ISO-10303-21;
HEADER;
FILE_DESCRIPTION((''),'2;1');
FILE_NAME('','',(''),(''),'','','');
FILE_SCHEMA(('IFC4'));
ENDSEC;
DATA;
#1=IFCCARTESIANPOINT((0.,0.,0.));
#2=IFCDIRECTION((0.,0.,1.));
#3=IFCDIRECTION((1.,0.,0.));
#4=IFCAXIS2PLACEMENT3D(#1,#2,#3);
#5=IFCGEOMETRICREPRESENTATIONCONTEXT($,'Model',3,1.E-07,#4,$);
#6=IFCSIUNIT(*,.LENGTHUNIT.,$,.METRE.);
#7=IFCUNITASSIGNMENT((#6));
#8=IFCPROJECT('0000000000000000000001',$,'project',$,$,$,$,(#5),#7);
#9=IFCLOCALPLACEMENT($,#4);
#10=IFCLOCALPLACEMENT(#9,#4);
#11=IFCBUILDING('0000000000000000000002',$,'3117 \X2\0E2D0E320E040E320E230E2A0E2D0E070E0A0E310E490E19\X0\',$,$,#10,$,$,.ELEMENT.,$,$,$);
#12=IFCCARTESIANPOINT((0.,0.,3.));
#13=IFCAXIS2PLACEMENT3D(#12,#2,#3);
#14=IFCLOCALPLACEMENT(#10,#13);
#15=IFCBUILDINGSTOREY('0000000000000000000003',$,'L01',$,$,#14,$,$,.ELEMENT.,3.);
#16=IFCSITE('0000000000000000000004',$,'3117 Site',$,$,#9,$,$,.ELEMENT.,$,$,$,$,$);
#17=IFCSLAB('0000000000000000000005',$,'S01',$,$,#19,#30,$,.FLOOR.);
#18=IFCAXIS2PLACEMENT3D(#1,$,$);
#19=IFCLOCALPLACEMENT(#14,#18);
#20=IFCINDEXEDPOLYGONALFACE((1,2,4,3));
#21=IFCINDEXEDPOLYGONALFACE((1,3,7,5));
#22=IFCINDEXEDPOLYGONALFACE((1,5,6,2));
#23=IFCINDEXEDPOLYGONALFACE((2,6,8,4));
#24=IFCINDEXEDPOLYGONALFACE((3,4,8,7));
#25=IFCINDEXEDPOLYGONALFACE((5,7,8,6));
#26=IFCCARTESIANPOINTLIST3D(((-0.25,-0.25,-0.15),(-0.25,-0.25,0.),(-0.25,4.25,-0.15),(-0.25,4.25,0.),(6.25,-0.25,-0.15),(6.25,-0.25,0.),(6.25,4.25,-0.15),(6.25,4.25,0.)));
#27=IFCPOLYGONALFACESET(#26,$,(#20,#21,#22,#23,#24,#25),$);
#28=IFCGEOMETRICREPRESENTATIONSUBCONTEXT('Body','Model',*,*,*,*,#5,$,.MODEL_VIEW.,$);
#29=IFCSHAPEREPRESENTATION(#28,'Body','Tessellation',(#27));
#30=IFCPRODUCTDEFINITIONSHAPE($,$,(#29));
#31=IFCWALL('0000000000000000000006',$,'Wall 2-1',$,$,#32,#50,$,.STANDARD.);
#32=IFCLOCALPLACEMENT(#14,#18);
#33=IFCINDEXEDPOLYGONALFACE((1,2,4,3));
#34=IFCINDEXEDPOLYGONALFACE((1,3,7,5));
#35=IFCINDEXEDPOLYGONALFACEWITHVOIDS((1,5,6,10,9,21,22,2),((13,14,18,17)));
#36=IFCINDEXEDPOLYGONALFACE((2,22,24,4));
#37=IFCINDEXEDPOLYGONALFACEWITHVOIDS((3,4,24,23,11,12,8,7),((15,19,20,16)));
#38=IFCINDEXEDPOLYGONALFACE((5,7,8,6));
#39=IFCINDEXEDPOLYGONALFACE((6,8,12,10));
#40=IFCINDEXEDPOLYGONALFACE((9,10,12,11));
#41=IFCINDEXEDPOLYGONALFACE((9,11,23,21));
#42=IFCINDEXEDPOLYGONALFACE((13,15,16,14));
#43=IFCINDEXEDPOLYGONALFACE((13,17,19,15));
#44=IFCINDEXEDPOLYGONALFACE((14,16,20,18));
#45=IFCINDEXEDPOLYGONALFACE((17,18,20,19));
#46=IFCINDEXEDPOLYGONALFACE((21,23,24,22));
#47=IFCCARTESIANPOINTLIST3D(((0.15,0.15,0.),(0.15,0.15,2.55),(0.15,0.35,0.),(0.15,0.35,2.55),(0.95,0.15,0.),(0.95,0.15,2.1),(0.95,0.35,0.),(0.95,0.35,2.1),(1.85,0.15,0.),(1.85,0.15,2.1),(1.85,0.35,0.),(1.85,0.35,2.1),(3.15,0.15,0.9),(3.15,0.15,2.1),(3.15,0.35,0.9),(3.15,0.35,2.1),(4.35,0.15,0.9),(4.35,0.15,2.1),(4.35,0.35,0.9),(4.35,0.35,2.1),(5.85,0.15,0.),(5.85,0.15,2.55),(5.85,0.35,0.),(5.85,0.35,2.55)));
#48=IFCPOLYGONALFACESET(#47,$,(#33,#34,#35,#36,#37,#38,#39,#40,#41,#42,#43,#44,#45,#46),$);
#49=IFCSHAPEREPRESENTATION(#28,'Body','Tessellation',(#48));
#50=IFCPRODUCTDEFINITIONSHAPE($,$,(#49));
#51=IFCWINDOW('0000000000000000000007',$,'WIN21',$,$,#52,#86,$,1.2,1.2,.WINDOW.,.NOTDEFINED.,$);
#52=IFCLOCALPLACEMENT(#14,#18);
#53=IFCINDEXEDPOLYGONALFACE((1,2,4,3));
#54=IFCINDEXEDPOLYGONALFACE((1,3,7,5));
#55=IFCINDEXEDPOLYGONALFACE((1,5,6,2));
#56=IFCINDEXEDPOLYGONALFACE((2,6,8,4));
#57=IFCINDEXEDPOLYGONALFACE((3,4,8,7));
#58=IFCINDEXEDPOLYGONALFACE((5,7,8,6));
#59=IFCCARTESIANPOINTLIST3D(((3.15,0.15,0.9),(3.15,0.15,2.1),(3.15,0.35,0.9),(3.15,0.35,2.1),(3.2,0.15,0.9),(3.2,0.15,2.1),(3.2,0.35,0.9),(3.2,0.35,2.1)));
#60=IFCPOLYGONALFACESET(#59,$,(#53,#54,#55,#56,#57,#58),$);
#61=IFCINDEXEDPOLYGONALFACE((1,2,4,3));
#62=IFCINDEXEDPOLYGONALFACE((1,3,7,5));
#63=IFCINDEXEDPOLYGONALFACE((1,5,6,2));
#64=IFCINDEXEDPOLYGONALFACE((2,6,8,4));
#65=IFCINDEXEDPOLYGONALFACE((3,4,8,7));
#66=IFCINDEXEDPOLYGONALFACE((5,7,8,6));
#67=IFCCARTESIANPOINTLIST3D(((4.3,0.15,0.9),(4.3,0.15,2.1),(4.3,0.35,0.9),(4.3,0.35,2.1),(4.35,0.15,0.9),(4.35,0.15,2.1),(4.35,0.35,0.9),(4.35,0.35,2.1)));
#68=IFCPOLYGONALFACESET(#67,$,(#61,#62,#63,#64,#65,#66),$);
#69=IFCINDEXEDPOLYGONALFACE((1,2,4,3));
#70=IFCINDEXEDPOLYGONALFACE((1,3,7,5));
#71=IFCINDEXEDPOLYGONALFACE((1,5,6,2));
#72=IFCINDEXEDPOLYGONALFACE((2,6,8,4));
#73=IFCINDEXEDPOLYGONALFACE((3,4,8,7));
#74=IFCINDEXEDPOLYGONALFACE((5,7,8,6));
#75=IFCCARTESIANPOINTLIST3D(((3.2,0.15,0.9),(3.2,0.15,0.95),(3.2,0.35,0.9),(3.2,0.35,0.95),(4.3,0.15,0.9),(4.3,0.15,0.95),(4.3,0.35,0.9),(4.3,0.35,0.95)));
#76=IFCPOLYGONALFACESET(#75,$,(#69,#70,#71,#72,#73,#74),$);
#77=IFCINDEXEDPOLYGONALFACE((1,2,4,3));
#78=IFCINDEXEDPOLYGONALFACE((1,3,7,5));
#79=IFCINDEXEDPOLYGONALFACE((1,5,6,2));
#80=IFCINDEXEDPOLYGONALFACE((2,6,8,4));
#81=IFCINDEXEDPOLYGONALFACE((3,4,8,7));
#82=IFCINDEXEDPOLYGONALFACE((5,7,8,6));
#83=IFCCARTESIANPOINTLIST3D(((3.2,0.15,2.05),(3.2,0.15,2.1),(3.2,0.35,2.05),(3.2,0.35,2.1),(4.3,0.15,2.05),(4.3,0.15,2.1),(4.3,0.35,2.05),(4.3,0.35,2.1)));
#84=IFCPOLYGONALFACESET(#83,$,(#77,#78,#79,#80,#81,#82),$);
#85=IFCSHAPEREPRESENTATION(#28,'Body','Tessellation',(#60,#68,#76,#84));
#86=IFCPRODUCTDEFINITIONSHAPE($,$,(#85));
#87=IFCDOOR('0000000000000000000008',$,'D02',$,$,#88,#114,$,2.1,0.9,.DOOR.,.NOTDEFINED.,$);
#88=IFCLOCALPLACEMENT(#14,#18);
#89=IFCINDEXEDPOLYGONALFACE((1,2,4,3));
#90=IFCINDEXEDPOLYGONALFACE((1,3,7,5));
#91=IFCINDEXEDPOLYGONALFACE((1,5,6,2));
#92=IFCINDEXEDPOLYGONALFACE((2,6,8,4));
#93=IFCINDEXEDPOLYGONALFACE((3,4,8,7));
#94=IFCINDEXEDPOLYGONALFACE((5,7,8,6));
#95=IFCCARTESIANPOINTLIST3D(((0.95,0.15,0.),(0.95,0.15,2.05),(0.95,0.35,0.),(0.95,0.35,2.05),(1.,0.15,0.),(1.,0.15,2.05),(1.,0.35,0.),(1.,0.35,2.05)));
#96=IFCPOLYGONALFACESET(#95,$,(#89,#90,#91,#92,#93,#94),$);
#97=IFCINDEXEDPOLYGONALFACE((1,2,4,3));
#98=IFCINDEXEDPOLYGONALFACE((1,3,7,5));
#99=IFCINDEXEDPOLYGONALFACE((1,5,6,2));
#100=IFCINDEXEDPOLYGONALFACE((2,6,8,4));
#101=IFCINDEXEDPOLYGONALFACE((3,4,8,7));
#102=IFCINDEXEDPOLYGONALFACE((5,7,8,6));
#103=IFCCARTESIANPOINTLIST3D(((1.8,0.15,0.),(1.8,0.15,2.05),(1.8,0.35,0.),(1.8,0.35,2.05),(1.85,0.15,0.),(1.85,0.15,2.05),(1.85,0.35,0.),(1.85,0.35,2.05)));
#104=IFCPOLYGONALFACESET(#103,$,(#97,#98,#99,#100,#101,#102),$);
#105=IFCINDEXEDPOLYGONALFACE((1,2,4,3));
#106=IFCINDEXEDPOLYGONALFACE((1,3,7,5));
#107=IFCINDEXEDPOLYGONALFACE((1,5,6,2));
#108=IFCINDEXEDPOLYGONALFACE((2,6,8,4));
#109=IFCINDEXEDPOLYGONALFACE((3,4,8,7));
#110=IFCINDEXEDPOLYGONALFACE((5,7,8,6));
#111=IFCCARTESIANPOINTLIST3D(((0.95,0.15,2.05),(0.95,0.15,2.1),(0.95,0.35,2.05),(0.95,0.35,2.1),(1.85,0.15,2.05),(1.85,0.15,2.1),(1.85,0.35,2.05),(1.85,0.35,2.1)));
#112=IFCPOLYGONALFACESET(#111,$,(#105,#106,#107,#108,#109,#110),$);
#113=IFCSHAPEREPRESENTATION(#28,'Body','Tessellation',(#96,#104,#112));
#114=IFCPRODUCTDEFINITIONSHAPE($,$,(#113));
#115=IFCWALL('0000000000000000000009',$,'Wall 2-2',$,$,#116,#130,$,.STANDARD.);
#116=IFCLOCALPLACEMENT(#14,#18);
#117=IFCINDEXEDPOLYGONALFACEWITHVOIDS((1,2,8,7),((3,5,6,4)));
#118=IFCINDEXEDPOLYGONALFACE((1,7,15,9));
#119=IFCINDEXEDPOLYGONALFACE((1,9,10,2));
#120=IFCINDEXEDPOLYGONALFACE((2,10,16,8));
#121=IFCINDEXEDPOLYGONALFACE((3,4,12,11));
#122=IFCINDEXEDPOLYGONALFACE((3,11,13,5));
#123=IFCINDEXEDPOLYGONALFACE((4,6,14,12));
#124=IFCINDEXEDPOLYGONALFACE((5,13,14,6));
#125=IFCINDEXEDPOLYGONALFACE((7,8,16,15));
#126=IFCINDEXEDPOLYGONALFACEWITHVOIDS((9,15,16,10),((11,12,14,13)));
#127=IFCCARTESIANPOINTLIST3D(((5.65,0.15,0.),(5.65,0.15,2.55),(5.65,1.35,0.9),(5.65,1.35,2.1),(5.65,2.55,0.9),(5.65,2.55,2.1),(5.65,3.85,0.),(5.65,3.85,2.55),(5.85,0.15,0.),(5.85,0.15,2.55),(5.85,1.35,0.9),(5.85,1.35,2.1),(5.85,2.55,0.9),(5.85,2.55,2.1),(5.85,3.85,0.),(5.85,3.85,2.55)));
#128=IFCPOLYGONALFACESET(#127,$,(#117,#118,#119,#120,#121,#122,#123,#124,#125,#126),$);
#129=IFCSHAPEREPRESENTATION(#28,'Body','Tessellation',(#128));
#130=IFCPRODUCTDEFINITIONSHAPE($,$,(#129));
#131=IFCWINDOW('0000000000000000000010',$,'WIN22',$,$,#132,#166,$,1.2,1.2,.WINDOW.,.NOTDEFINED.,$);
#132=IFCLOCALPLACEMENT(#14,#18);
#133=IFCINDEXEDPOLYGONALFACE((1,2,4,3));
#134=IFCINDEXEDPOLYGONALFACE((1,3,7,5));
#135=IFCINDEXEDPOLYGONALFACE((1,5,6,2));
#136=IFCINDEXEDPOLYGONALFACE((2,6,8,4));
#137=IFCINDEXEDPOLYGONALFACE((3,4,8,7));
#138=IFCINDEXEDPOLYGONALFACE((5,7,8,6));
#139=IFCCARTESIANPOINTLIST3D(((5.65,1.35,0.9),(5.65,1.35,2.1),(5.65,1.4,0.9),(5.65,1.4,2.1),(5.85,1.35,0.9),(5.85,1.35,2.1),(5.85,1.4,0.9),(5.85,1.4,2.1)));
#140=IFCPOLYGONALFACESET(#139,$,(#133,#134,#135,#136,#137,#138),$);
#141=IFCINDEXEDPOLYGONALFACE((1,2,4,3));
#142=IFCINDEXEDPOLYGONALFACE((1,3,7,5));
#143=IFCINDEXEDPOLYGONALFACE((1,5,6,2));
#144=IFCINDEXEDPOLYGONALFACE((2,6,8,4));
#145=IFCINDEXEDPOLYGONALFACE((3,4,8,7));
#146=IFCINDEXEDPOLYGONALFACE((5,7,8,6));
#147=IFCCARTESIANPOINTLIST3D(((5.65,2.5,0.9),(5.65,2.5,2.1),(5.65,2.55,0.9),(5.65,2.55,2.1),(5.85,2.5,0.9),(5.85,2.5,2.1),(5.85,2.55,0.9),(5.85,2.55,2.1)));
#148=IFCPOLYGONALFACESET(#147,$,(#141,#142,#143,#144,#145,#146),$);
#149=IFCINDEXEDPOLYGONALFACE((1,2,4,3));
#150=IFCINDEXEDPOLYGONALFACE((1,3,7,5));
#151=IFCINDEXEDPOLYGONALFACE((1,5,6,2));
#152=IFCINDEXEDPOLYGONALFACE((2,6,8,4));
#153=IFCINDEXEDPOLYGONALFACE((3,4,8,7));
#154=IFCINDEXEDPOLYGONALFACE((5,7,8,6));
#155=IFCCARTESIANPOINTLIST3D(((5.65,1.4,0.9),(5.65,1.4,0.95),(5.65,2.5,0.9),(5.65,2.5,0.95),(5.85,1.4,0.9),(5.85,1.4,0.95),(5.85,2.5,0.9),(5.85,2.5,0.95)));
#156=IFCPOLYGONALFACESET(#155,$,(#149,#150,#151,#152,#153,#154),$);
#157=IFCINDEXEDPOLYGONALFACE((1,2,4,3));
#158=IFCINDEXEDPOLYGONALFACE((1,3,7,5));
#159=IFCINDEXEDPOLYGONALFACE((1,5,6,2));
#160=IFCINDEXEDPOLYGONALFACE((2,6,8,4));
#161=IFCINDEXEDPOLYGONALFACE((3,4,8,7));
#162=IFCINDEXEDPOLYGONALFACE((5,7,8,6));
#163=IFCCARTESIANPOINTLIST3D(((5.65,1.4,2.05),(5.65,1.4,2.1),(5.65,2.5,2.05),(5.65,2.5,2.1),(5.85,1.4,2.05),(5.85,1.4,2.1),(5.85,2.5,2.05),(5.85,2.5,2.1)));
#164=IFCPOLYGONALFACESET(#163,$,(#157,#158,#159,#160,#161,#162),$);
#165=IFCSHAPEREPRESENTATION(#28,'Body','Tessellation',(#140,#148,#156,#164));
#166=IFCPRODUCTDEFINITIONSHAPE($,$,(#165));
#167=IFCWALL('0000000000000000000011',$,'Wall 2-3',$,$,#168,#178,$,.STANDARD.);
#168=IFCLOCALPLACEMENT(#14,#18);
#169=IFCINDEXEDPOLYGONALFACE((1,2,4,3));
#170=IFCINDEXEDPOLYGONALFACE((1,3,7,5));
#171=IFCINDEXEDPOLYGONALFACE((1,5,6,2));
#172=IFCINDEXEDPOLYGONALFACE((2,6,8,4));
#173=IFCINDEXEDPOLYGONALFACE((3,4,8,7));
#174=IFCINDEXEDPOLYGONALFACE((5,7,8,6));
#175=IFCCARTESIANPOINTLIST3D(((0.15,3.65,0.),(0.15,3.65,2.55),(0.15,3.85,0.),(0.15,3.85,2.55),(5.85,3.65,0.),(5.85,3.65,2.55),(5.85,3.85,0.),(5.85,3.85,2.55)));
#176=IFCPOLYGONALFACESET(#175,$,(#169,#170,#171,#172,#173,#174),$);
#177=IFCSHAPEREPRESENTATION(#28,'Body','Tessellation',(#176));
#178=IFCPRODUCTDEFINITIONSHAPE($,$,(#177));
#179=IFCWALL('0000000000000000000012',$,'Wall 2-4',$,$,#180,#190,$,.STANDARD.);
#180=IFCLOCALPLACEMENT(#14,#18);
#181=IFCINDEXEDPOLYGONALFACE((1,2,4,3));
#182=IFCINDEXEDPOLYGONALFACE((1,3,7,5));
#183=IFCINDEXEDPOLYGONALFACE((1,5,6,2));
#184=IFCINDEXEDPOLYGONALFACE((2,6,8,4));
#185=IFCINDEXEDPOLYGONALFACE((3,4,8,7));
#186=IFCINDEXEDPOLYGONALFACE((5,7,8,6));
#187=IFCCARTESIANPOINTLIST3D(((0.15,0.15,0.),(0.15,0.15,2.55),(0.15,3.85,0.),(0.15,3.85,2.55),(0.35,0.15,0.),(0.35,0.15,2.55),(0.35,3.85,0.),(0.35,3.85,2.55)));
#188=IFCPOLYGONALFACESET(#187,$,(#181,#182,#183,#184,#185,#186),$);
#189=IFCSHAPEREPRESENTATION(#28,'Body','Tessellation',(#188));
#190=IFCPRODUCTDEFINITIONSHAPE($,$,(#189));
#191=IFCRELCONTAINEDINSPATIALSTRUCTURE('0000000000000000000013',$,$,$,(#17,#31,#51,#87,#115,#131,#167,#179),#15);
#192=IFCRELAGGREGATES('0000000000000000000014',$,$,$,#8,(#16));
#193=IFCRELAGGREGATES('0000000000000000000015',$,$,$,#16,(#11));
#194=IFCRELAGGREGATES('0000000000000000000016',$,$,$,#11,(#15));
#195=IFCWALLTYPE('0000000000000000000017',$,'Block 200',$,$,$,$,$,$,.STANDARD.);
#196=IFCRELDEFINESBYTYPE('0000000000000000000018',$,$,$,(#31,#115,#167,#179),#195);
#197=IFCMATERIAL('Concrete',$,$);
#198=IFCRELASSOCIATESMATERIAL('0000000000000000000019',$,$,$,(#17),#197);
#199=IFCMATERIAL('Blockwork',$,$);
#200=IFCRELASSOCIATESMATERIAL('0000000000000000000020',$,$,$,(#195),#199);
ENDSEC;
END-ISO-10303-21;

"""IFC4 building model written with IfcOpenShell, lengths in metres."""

from ifc_helpers import new_model, si_unit, frame, origin_with_axes, place, context, subcontext, project, spatial, polyline, outline, extrude, material, type_object, element, fill, save


model = new_model("IFC4")

# Units and contexts
model_context = context("Model", 3, precision=1e-07, world=origin_with_axes())
body_context = subcontext(model_context, "Body", "Model", "MODEL_VIEW")
ifc_project = project(units=[si_unit("LENGTHUNIT", "METRE")], contexts=[model_context])

# Site, building, storey
site_placement = place(None, origin_with_axes())
site = spatial("IfcSite", under=ifc_project, at=site_placement, Name="3117 Site", CompositionType="ELEMENT")
building_placement = place(site_placement, origin_with_axes())
building = spatial("IfcBuilding", under=site, at=building_placement, Name="3117 อาคารสองชั้น", CompositionType="ELEMENT")
storey_placement = place(building_placement, frame((0.0, 0.0, 3.0), z_axis=(0.0, 0.0, 1.0), x_axis=(1.0, 0.0, 0.0)))
storey = spatial("IfcBuildingStorey", under=building, at=storey_placement, Name="L01", CompositionType="ELEMENT", Elevation=3.0)

# Slab
ifc_material_1 = material(Name="Concrete")
slab_placement = place(storey_placement, frame((0.0, 0.0, -0.15), z_axis=(0.0, 0.0, 1.0), x_axis=(1.0, 0.0, 0.0)))
element("IfcSlab", 1, at=slab_placement, inside=storey, material=ifc_material_1, Name="S01", PredefinedType="FLOOR", context=body_context, shape_type="SweptSolid", body=[
    extrude(outline(polyline([(-0.25, -0.25), (6.25, -0.25), (6.25, 4.25), (-0.25, 4.25), (-0.25, -0.25)])), origin_with_axes(), (0.0, 0.0, 1.0), 0.15),
])

# Wall, openings, window, door
ifc_material_2 = material(Name="Blockwork")
wall_type = type_object("IfcWallType", Name="Block 200", PredefinedType="STANDARD", material=ifc_material_2)
wall_1_placement = place(storey_placement, frame((0.15, 0.15, 0.0), z_axis=(0.0, 0.0, 1.0), x_axis=(1.0, 0.0, 0.0)))
wall_1 = element("IfcWall", 2, at=wall_1_placement, inside=storey, type_object=wall_type, Name="Wall 2-1", PredefinedType="STANDARD", context=body_context, shape_type="SweptSolid", body=[
    extrude(outline(polyline([(0.0, 0.0), (5.7, 0.0), (5.7, 0.2), (0.0, 0.2), (0.0, 0.0)])), origin_with_axes(), (0.0, 0.0, 1.0), 2.55),
])
opening_1_placement = place(wall_1_placement, frame((3.0, 0.0, 0.9), z_axis=(0.0, 0.0, 1.0), x_axis=(1.0, 0.0, 0.0)))
opening_1 = element("IfcOpeningElement", 3, at=opening_1_placement, cuts=wall_1, PredefinedType="OPENING", context=body_context, shape_type="SweptSolid", body=[
    extrude(outline(polyline([(0.0, 0.0), (1.2, 0.0), (1.2, 0.2), (0.0, 0.2), (0.0, 0.0)])), origin_with_axes(), (0.0, 0.0, 1.0), 1.2),
])
opening_2_placement = place(wall_1_placement, frame((0.8, 0.0, 0.0), z_axis=(0.0, 0.0, 1.0), x_axis=(1.0, 0.0, 0.0)))
opening_2 = element("IfcOpeningElement", 4, at=opening_2_placement, cuts=wall_1, PredefinedType="OPENING", context=body_context, shape_type="SweptSolid", body=[
    extrude(outline(polyline([(0.0, 0.0), (0.9, 0.0), (0.9, 0.2), (0.0, 0.2), (0.0, 0.0)])), origin_with_axes(), (0.0, 0.0, 1.0), 2.1),
])
window_1_placement = place(opening_1_placement, frame((0.0, 0.0, 0.0), z_axis=(0.0, 0.0, 1.0), x_axis=(1.0, 0.0, 0.0)))
window_1 = element("IfcWindow", 5, at=window_1_placement, inside=storey, Name="WIN21", OverallHeight=1.2, OverallWidth=1.2, PartitioningType="NOTDEFINED", PredefinedType="WINDOW", context=body_context, shape_type="SweptSolid", body=[
    extrude(outline(polyline([(0.0, 0.0), (0.05, 0.0), (0.05, 0.2), (0.0, 0.2), (0.0, 0.0)])), origin_with_axes(), (0.0, 0.0, 1.0), 1.2),
    extrude(outline(polyline([(0.0, 0.0), (0.05, 0.0), (0.05, 0.2), (0.0, 0.2), (0.0, 0.0)])), frame((1.15, 0.0, 0.0), z_axis=(0.0, 0.0, 1.0), x_axis=(1.0, 0.0, 0.0)), (0.0, 0.0, 1.0), 1.2),
    extrude(outline(polyline([(0.0, 0.0), (1.1, 0.0), (1.1, 0.2), (0.0, 0.2), (0.0, 0.0)])), frame((0.05, 0.0, 0.0), z_axis=(0.0, 0.0, 1.0), x_axis=(1.0, 0.0, 0.0)), (0.0, 0.0, 1.0), 0.05),
    extrude(outline(polyline([(0.0, 0.0), (1.1, 0.0), (1.1, 0.2), (0.0, 0.2), (0.0, 0.0)])), frame((0.05, 0.0, 1.15), z_axis=(0.0, 0.0, 1.0), x_axis=(1.0, 0.0, 0.0)), (0.0, 0.0, 1.0), 0.05),
])
fill(opening_1, window_1)
door_placement = place(opening_2_placement, frame((0.0, 0.0, 0.0), z_axis=(0.0, 0.0, 1.0), x_axis=(1.0, 0.0, 0.0)))
door = element("IfcDoor", 6, at=door_placement, inside=storey, Name="D02", OperationType="NOTDEFINED", OverallHeight=2.1, OverallWidth=0.9, PredefinedType="DOOR", context=body_context, shape_type="SweptSolid", body=[
    extrude(outline(polyline([(0.0, 0.0), (0.05, 0.0), (0.05, 0.2), (0.0, 0.2), (0.0, 0.0)])), origin_with_axes(), (0.0, 0.0, 1.0), 2.05),
    extrude(outline(polyline([(0.0, 0.0), (0.05, 0.0), (0.05, 0.2), (0.0, 0.2), (0.0, 0.0)])), frame((0.85, 0.0, 0.0), z_axis=(0.0, 0.0, 1.0), x_axis=(1.0, 0.0, 0.0)), (0.0, 0.0, 1.0), 2.05),
    extrude(outline(polyline([(0.0, 0.0), (0.9, 0.0), (0.9, 0.2), (0.0, 0.2), (0.0, 0.0)])), frame((0.0, 0.0, 2.05), z_axis=(0.0, 0.0, 1.0), x_axis=(1.0, 0.0, 0.0)), (0.0, 0.0, 1.0), 0.05),
])
fill(opening_2, door)

# Wall, opening, window
wall_2_placement = place(storey_placement, frame((5.85, 0.15, 0.0), z_axis=(0.0, 0.0, 1.0), x_axis=(0.0, 1.0, 0.0)))
wall_2 = element("IfcWall", 7, at=wall_2_placement, inside=storey, type_object=wall_type, Name="Wall 2-2", PredefinedType="STANDARD", context=body_context, shape_type="SweptSolid", body=[
    extrude(outline(polyline([(0.0, 0.0), (3.7, 0.0), (3.7, 0.2), (0.0, 0.2), (0.0, 0.0)])), origin_with_axes(), (0.0, 0.0, 1.0), 2.55),
])
opening_3_placement = place(wall_2_placement, frame((1.2, 0.0, 0.9), z_axis=(0.0, 0.0, 1.0), x_axis=(1.0, 0.0, 0.0)))
opening_3 = element("IfcOpeningElement", 8, at=opening_3_placement, cuts=wall_2, PredefinedType="OPENING", context=body_context, shape_type="SweptSolid", body=[
    extrude(outline(polyline([(0.0, 0.0), (1.2, 0.0), (1.2, 0.2), (0.0, 0.2), (0.0, 0.0)])), origin_with_axes(), (0.0, 0.0, 1.0), 1.2),
])
window_2_placement = place(opening_3_placement, frame((0.0, 0.0, 0.0), z_axis=(0.0, 0.0, 1.0), x_axis=(1.0, 0.0, 0.0)))
window_2 = element("IfcWindow", 9, at=window_2_placement, inside=storey, Name="WIN22", OverallHeight=1.2, OverallWidth=1.2, PartitioningType="NOTDEFINED", PredefinedType="WINDOW", context=body_context, shape_type="SweptSolid", body=[
    extrude(outline(polyline([(0.0, 0.0), (0.05, 0.0), (0.05, 0.2), (0.0, 0.2), (0.0, 0.0)])), origin_with_axes(), (0.0, 0.0, 1.0), 1.2),
    extrude(outline(polyline([(0.0, 0.0), (0.05, 0.0), (0.05, 0.2), (0.0, 0.2), (0.0, 0.0)])), frame((1.15, 0.0, 0.0), z_axis=(0.0, 0.0, 1.0), x_axis=(1.0, 0.0, 0.0)), (0.0, 0.0, 1.0), 1.2),
    extrude(outline(polyline([(0.0, 0.0), (1.1, 0.0), (1.1, 0.2), (0.0, 0.2), (0.0, 0.0)])), frame((0.05, 0.0, 0.0), z_axis=(0.0, 0.0, 1.0), x_axis=(1.0, 0.0, 0.0)), (0.0, 0.0, 1.0), 0.05),
    extrude(outline(polyline([(0.0, 0.0), (1.1, 0.0), (1.1, 0.2), (0.0, 0.2), (0.0, 0.0)])), frame((0.05, 0.0, 1.15), z_axis=(0.0, 0.0, 1.0), x_axis=(1.0, 0.0, 0.0)), (0.0, 0.0, 1.0), 0.05),
])
fill(opening_3, window_2)

# Walls
wall_3_placement = place(storey_placement, frame((5.85, 3.85, 0.0), z_axis=(0.0, 0.0, 1.0), x_axis=(-1.0, 0.0, 0.0)))
element("IfcWall", 10, at=wall_3_placement, inside=storey, type_object=wall_type, Name="Wall 2-3", PredefinedType="STANDARD", context=body_context, shape_type="SweptSolid", body=[
    extrude(outline(polyline([(0.0, 0.0), (5.7, 0.0), (5.7, 0.2), (0.0, 0.2), (0.0, 0.0)])), origin_with_axes(), (0.0, 0.0, 1.0), 2.55),
])
wall_4_placement = place(storey_placement, frame((0.15, 3.85, 0.0), z_axis=(0.0, 0.0, 1.0), x_axis=(0.0, -1.0, 0.0)))
element("IfcWall", 11, at=wall_4_placement, inside=storey, type_object=wall_type, Name="Wall 2-4", PredefinedType="STANDARD", context=body_context, shape_type="SweptSolid", body=[
    extrude(outline(polyline([(0.0, 0.0), (3.7, 0.0), (3.7, 0.2), (0.0, 0.2), (0.0, 0.0)])), origin_with_axes(), (0.0, 0.0, 1.0), 2.55),
])

save(model, "model.ifc")
